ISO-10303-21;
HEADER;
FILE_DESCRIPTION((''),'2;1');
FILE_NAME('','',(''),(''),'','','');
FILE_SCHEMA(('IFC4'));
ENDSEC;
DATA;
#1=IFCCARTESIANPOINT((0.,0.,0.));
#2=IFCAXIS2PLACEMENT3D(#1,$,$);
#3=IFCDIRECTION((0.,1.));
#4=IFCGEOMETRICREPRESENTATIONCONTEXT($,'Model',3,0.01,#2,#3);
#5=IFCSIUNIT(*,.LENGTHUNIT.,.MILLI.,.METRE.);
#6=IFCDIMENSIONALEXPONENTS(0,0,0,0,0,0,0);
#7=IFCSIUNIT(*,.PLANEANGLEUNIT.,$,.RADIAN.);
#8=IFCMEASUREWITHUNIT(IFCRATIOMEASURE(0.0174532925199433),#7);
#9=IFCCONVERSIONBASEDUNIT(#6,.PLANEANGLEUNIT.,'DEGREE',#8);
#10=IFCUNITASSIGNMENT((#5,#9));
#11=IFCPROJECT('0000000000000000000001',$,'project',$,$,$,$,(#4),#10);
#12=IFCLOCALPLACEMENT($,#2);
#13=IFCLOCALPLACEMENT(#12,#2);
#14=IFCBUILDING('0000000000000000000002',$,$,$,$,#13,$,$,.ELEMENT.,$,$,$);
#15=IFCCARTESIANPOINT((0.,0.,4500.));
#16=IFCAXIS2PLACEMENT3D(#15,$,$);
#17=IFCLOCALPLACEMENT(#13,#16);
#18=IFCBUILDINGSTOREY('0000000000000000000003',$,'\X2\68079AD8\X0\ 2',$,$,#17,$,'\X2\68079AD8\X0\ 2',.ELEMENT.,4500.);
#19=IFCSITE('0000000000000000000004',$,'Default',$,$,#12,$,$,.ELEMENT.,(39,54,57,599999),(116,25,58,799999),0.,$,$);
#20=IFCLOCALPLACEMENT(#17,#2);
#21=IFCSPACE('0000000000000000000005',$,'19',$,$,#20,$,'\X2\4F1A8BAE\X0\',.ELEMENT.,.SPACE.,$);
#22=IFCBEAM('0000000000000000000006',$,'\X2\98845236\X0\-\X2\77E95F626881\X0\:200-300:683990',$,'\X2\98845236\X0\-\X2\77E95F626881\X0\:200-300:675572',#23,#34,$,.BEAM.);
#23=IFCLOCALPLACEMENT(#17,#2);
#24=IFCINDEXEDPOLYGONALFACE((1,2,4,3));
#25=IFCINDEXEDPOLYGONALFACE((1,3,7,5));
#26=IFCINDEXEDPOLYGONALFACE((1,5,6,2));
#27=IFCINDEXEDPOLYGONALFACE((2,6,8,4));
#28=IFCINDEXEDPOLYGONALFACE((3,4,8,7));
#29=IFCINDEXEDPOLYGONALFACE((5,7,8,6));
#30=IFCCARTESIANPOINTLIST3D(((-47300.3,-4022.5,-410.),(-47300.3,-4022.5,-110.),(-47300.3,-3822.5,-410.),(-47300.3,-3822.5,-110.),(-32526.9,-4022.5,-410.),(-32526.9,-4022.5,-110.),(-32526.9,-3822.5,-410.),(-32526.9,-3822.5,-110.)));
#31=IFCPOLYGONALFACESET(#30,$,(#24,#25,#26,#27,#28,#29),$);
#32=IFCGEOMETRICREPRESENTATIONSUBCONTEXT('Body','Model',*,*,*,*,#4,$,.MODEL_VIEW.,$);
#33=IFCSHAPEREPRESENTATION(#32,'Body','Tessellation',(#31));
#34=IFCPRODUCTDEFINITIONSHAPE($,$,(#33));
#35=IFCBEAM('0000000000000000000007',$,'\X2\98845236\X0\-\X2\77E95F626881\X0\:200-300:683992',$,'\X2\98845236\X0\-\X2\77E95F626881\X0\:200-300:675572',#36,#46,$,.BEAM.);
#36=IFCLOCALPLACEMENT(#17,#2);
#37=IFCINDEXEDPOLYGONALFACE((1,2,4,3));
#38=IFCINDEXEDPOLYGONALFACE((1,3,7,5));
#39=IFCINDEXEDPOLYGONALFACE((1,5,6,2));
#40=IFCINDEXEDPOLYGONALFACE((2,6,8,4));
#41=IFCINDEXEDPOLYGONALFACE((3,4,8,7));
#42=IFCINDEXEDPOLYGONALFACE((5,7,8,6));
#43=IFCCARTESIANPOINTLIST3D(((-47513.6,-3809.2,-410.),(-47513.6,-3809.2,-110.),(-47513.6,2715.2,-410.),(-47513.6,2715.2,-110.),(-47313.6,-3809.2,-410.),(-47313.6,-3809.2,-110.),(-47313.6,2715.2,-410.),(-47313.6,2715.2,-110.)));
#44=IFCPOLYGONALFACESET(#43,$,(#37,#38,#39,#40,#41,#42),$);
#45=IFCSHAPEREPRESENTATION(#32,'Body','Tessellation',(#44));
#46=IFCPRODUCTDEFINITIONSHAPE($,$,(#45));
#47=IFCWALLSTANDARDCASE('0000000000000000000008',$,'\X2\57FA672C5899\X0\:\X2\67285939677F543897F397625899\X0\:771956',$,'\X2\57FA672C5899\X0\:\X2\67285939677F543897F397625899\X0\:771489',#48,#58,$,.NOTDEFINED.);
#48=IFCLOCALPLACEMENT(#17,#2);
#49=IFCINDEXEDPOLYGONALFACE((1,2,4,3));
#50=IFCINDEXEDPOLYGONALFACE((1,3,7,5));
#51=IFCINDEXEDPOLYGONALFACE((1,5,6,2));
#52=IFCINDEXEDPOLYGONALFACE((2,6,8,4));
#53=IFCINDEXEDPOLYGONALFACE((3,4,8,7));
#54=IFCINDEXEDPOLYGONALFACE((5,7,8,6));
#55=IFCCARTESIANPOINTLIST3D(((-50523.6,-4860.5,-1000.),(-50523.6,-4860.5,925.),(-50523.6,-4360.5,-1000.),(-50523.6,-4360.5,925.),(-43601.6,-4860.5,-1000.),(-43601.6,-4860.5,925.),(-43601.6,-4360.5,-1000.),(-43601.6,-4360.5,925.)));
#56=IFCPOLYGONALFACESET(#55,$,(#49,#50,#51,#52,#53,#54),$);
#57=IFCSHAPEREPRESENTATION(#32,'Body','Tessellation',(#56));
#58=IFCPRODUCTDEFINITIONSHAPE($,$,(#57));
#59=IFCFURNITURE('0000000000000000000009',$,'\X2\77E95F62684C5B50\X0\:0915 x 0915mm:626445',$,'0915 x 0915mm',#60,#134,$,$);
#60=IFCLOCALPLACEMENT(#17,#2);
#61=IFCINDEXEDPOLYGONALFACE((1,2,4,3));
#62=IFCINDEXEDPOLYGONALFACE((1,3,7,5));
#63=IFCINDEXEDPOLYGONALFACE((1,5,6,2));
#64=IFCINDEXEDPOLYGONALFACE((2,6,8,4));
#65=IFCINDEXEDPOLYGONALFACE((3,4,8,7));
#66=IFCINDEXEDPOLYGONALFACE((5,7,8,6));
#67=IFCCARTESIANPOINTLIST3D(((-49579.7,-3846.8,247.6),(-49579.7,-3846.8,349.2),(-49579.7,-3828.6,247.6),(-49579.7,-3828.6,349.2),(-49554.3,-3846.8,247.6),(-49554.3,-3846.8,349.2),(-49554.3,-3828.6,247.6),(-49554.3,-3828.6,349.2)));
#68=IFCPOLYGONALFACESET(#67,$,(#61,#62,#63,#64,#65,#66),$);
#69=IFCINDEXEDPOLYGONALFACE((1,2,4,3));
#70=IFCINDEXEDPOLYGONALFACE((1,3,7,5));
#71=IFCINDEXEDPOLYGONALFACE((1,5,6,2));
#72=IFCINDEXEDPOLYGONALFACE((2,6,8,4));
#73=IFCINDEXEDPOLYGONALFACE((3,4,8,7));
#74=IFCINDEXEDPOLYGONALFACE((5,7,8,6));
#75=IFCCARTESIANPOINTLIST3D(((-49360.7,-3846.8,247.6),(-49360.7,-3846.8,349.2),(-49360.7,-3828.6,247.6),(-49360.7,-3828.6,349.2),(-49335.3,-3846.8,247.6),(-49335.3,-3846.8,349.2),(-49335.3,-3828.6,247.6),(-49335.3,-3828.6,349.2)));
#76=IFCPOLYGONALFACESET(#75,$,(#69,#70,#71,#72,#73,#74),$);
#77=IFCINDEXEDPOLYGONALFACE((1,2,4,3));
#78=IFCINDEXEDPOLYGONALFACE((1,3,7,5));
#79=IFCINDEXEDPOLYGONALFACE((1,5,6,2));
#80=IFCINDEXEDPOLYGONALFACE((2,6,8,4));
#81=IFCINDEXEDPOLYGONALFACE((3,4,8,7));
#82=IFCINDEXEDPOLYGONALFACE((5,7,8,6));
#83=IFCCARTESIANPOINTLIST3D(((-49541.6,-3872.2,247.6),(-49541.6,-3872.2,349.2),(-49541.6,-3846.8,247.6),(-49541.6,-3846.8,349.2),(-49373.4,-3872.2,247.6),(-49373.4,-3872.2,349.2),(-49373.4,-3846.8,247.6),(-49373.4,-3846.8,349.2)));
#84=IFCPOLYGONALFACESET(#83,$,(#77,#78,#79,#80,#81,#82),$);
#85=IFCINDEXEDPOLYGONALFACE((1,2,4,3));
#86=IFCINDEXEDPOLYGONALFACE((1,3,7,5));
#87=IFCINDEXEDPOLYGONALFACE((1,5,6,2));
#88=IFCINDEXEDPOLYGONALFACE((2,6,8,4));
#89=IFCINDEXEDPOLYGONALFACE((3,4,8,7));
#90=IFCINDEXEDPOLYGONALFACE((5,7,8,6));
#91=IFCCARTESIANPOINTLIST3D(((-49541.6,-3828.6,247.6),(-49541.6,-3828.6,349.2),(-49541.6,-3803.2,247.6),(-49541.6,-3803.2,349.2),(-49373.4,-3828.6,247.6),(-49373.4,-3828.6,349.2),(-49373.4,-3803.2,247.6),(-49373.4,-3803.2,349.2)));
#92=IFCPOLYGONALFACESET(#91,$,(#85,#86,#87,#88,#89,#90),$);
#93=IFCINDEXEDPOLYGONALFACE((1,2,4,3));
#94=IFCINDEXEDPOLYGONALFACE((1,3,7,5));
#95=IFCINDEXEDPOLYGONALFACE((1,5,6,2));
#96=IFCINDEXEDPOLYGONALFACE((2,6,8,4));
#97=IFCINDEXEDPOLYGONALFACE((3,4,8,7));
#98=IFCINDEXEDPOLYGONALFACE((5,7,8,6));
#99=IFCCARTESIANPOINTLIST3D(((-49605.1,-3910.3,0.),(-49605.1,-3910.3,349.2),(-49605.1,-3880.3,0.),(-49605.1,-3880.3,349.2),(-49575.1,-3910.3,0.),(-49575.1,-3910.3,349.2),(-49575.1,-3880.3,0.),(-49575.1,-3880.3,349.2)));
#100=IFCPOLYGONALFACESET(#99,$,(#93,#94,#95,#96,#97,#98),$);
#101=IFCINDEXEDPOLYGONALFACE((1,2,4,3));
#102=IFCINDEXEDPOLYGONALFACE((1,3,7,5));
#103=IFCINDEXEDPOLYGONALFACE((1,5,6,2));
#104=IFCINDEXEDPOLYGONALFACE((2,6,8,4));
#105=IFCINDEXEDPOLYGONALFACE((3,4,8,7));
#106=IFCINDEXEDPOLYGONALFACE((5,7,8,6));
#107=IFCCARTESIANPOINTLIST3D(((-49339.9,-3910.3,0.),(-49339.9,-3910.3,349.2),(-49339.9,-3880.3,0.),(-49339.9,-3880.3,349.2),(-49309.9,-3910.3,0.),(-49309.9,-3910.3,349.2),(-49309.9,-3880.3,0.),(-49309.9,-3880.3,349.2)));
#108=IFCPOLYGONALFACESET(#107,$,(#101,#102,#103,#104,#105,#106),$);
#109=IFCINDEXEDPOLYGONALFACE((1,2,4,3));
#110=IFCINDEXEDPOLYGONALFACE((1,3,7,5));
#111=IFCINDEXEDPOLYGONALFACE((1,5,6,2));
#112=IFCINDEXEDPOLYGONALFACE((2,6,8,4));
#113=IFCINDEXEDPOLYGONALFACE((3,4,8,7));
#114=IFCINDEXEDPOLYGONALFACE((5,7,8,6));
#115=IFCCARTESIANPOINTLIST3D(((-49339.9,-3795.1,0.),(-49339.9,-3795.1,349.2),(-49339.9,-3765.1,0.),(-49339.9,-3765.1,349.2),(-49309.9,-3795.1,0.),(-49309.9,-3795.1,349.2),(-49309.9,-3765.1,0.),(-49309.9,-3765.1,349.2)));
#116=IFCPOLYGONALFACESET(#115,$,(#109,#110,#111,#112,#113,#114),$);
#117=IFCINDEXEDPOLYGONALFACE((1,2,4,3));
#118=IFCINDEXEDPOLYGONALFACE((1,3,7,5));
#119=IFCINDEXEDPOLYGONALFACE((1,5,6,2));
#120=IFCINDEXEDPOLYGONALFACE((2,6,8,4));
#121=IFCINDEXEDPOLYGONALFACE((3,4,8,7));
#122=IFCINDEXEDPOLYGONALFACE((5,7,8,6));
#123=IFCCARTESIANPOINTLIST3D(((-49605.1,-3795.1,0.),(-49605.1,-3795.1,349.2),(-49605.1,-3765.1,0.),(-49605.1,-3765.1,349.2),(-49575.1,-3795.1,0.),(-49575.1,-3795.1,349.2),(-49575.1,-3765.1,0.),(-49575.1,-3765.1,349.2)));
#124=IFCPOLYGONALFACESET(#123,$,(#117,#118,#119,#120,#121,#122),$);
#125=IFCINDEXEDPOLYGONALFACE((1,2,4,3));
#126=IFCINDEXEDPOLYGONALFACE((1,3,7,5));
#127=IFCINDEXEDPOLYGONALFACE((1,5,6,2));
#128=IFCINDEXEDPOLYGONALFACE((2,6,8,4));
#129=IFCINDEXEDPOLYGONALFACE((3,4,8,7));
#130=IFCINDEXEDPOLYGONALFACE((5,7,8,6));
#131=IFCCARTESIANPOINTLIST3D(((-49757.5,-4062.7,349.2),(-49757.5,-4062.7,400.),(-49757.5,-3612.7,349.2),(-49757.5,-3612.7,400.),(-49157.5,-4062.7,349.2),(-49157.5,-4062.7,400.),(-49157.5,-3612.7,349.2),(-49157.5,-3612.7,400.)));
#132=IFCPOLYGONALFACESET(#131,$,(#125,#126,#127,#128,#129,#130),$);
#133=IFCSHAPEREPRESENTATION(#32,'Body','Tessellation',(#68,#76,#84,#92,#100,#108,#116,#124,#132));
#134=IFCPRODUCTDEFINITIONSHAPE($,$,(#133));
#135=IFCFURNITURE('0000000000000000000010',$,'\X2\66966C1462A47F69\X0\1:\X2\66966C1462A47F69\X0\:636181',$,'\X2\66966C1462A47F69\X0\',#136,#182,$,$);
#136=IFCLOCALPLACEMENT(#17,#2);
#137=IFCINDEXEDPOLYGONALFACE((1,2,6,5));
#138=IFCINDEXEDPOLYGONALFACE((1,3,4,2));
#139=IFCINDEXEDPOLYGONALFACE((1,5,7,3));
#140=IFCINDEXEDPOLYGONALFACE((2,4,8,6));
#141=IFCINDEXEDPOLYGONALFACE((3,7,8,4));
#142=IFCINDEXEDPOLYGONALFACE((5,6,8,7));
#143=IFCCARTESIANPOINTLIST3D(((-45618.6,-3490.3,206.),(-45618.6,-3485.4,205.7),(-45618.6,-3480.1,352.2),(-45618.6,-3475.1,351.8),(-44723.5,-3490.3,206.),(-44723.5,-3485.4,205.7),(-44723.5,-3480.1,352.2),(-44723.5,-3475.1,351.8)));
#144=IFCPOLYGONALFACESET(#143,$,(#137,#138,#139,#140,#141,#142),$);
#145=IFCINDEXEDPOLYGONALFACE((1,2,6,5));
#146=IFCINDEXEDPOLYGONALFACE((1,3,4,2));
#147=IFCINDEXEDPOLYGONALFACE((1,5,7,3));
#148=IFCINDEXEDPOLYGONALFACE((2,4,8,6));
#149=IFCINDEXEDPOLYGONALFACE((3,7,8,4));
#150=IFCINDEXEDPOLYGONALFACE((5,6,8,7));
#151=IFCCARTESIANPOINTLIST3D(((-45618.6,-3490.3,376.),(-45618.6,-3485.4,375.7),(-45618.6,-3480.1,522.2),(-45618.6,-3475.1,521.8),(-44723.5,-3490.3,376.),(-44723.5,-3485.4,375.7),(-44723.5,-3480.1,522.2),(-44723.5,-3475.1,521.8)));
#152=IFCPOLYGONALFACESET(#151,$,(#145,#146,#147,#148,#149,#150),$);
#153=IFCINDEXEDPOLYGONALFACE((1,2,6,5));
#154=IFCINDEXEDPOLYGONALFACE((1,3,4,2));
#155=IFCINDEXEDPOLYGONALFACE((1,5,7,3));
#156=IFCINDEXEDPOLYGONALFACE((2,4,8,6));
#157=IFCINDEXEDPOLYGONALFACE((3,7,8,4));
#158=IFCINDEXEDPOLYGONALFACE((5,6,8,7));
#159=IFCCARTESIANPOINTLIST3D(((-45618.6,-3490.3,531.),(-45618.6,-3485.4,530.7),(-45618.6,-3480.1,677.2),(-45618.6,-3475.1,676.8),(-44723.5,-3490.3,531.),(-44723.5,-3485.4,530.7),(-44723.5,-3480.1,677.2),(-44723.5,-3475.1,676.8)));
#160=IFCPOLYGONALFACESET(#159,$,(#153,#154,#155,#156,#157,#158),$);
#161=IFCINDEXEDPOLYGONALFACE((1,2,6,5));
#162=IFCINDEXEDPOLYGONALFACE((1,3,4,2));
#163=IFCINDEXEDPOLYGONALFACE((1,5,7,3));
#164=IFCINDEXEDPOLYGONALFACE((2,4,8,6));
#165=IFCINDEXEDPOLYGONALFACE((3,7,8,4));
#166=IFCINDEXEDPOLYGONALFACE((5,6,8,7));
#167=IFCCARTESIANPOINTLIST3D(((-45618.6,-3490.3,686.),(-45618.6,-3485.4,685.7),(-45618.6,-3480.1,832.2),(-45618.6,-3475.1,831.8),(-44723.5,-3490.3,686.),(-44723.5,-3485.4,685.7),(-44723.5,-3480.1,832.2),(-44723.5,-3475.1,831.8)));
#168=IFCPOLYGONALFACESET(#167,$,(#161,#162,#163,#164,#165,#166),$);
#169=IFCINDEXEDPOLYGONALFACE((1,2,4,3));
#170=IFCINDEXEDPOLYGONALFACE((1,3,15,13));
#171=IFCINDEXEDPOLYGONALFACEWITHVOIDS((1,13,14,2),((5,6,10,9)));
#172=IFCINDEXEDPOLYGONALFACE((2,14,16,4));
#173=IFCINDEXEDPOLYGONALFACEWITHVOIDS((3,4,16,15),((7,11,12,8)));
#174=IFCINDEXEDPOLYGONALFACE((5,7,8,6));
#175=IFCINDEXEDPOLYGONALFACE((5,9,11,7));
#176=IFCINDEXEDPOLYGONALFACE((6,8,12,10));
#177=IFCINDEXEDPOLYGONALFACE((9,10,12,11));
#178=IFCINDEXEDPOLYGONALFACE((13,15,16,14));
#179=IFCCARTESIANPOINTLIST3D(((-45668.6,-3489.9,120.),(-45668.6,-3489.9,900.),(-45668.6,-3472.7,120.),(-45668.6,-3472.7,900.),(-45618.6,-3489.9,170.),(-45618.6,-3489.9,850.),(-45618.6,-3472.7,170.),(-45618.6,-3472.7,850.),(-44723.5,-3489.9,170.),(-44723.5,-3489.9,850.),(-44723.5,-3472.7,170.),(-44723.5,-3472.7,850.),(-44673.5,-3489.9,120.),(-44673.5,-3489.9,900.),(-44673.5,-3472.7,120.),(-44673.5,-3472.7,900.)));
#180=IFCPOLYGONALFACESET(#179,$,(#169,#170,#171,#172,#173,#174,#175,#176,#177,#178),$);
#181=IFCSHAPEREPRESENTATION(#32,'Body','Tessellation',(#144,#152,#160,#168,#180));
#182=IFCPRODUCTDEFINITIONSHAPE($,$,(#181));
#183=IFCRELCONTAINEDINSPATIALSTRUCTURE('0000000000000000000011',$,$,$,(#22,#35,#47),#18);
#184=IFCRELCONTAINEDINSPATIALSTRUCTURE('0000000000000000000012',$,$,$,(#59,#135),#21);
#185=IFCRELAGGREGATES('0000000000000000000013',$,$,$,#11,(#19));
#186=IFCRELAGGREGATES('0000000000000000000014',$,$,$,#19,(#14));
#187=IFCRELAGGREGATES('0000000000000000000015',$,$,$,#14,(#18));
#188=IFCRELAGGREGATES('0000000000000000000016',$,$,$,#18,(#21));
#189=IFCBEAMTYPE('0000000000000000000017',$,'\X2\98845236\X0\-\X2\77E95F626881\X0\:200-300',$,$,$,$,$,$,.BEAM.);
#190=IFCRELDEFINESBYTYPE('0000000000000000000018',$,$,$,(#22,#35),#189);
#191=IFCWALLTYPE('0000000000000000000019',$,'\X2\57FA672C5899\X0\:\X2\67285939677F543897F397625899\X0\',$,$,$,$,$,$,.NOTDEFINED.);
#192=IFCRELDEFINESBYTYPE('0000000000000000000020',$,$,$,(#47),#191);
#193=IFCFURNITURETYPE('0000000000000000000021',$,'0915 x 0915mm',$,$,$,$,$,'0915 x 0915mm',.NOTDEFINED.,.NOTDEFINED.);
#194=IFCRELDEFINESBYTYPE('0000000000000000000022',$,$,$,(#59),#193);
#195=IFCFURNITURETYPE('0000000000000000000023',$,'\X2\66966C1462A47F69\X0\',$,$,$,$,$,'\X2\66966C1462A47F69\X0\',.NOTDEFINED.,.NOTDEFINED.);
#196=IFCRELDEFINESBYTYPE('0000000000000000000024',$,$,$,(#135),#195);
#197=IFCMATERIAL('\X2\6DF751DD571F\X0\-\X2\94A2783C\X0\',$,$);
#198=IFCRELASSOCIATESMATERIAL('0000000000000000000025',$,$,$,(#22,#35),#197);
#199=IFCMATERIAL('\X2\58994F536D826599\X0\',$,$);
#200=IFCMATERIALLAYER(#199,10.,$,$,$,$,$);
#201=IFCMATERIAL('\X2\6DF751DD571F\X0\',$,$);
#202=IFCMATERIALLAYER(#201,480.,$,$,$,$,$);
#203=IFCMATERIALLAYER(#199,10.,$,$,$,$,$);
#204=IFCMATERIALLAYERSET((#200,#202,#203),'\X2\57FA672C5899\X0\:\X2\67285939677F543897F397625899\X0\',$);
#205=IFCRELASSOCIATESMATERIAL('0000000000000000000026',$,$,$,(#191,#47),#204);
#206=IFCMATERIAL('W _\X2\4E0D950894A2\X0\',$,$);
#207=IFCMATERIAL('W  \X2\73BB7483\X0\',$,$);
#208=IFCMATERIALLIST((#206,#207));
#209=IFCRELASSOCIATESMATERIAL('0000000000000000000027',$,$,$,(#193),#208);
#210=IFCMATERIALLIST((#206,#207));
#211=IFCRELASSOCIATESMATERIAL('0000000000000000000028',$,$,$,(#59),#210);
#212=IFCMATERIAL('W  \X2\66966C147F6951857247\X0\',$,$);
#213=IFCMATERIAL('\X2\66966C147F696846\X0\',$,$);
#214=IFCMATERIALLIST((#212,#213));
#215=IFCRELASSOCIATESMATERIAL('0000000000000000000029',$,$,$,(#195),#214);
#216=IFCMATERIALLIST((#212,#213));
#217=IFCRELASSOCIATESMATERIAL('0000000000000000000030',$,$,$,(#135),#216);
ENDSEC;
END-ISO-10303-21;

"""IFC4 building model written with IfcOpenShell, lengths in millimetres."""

from ifc_helpers import new_model, entity, si_unit, converted_unit, direction, frame, frame_2d, origin, origin_2d_with_axis, place, context, subcontext, project, spatial, polyline, rectangle, outline, extrude, source, transform, mapped, material, material_list, layer, layer_set, layer_usage, type_object, type_shapes, element, save


model = new_model("IFC4")

# Units and contexts
model_context = context("Model", 3, precision=0.01, world=origin(), true_north=direction((0.0, 1.0)))
body_context = subcontext(model_context, "Body", "Model", "MODEL_VIEW")
ifc_project = project(units=[si_unit("LENGTHUNIT", "METRE", prefix="MILLI"), converted_unit("PLANEANGLEUNIT", "DEGREE", entity("IfcRatioMeasure", 0.0174532925199433), si_unit("PLANEANGLEUNIT", "RADIAN"), dimensions=[0, 0, 0, 0, 0, 0, 0])], contexts=[model_context])

# Site, building, storey
site_placement = place(None, origin())
site = spatial("IfcSite", under=ifc_project, at=site_placement, Name="Default", CompositionType="ELEMENT", RefLatitude=(39, 54, 57, 599999), RefLongitude=(116, 25, 58, 799999), RefElevation=0.0)
building_placement = place(site_placement, origin())
building = spatial("IfcBuilding", under=site, at=building_placement, CompositionType="ELEMENT")
storey_placement = place(building_placement, frame((0.0, 0.0, 4500.0)))
storey = spatial("IfcBuildingStorey", under=building, at=storey_placement, Name="标高 2", LongName="标高 2", CompositionType="ELEMENT", Elevation=4500.0)

# Beams
ifc_material_1 = material(Name="混凝土-钢砼")
beam_type = type_object("IfcBeamType", Name="预制-矩形梁:200-300", PredefinedType="BEAM")
beam_1_placement = place(storey_placement, frame((-47413.6, -3922.5, -110.0)))
element("IfcBeam", 1, at=beam_1_placement, inside=storey, type_object=beam_type, material=ifc_material_1, Name="预制-矩形梁:200-300:683990", ObjectType="预制-矩形梁:200-300:675572", PredefinedType="BEAM", context=body_context, shape_type="SweptSolid", body=[
    extrude(rectangle(XDim=300.0, YDim=200.0, at=frame_2d((0.0, 0.0), x_axis=(1.0, 0.0))), frame((113.3, 0.0, -150.0), z_axis=(1.0, 0.0, 0.0), x_axis=(0.0, 0.0, -1.0)), (0.0, 0.0, 1.0), 14773.4),
])
beam_2_placement = place(storey_placement, frame((-47413.6, -3922.5, -110.0), z_axis=(0.0, 0.0, 1.0), x_axis=(0.0, 1.0, 0.0)))
element("IfcBeam", 2, at=beam_2_placement, inside=storey, type_object=beam_type, material=ifc_material_1, Name="预制-矩形梁:200-300:683992", ObjectType="预制-矩形梁:200-300:675572", PredefinedType="BEAM", context=body_context, shape_type="SweptSolid", body=[
    extrude(rectangle(XDim=300.0, YDim=200.0, at=origin_2d_with_axis()), frame((113.3, 0.0, -150.0), z_axis=(1.0, 0.0, 0.0), x_axis=(0.0, 0.0, -1.0)), (0.0, 0.0, 1.0), 6524.4),
])

# Wall
ifc_material_2 = material(Name="墙体涂料")
ifc_layer_1 = layer(ifc_material_2, 10.0)
ifc_material_3 = material(Name="混凝土")
ifc_layer_2 = layer(ifc_material_3, 480.0)
ifc_layer_3 = layer(ifc_material_2, 10.0)
ifc_layer_set = layer_set([ifc_layer_1, ifc_layer_2, ifc_layer_3], Name="基本墙:木夹板吸音面墙")
ifc_layer_usage = layer_usage(ifc_layer_set, "AXIS2", "NEGATIVE", 250.0)
wall_type = type_object("IfcWallType", Name="基本墙:木夹板吸音面墙", PredefinedType="NOTDEFINED", material=ifc_layer_set)
wall_placement = place(storey_placement, frame((-43601.6, -4610.5, -1000.0), z_axis=(0.0, 0.0, 1.0), x_axis=(-1.0, 0.0, 0.0)))
element("IfcWallStandardCase", 3, at=wall_placement, inside=storey, type_object=wall_type, material=ifc_layer_usage, Name="基本墙:木夹板吸音面墙:771956", ObjectType="基本墙:木夹板吸音面墙:771489", PredefinedType="NOTDEFINED", context=body_context, shape_type="SweptSolid", body=[
    extrude(rectangle(XDim=6922.0, YDim=500.0, at=frame_2d((3461.0, 0.0), x_axis=(-1.0, 0.0))), origin(), (0.0, 0.0, 1.0), 1925.0),
])

# Shared definitions
space_placement = place(storey_placement, origin())
space = spatial("IfcSpace", under=storey, at=space_placement, Name="19", LongName="会议", CompositionType="ELEMENT", PredefinedType="SPACE")

# Furniture
ifc_material_4 = material(Name="W _不锈钢")
ifc_material_5 = material(Name="W  玻璃")
ifc_material_list_1 = material_list([ifc_material_4, ifc_material_5])
ifc_material_list_2 = material_list([ifc_material_4, ifc_material_5])
furniture_type_1 = type_object("IfcFurnitureType", Name="0915 x 0915mm", ElementType="0915 x 0915mm", AssemblyPlace="NOTDEFINED", PredefinedType="NOTDEFINED", material=ifc_material_list_2)
shared_shape_1 = source(origin(), body_context, "Body", "SweptSolid", [
    extrude(rectangle(XDim=25.4, YDim=18.2, at=origin_2d_with_axis()), frame((109.5, 0.0, 247.6)), (0.0, 0.0, 1.0), 101.6),
    extrude(rectangle(XDim=18.2, YDim=25.4, at=origin_2d_with_axis()), frame((-109.5, 0.0, 247.6), z_axis=(0.0, 0.0, 1.0), x_axis=(0.0, 1.0, 0.0)), (0.0, 0.0, 1.0), 101.6),
    extrude(rectangle(XDim=168.2, YDim=25.4, at=frame_2d((0.0, 0.0), x_axis=(1.0, 0.0))), frame((0.0, 21.8, 247.6), z_axis=(0.0, 0.0, 1.0), x_axis=(-1.0, 0.0, 0.0)), (0.0, 0.0, 1.0), 101.6),
    extrude(rectangle(XDim=25.4, YDim=168.2, at=origin_2d_with_axis()), frame((0.0, -21.8, 247.6), z_axis=(0.0, 0.0, 1.0), x_axis=(0.0, 1.0, 0.0)), (0.0, 0.0, 1.0), 101.6),
    extrude(rectangle(XDim=30.0, YDim=30.0, at=origin_2d_with_axis()), frame((132.6, 57.6, 0.0), z_axis=(0.0, 0.0, 1.0), x_axis=(0.0, -1.0, 0.0)), (0.0, 0.0, 1.0), 349.2),
    extrude(rectangle(XDim=30.0, YDim=30.0, at=frame_2d((0.0, 0.0), x_axis=(1.0, 0.0))), frame((-132.6, 57.6, 0.0), z_axis=(0.0, 0.0, 1.0), x_axis=(-1.0, 0.0, 0.0)), (0.0, 0.0, 1.0), 349.2),
    extrude(rectangle(XDim=30.0, YDim=30.0, at=frame_2d((0.0, 0.0), x_axis=(1.0, 0.0))), frame((-132.6, -57.6, 0.0), z_axis=(0.0, 0.0, 1.0), x_axis=(0.0, 1.0, 0.0)), (0.0, 0.0, 1.0), 349.2),
    extrude(rectangle(XDim=30.0, YDim=30.0, at=frame_2d((0.0, 0.0), x_axis=(1.0, 0.0))), frame((132.6, -57.6, 0.0)), (0.0, 0.0, 1.0), 349.2),
    extrude(rectangle(XDim=600.0, YDim=450.0, at=origin_2d_with_axis()), frame((0.0, 0.0, 349.2), z_axis=(0.0, 0.0, 1.0), x_axis=(-1.0, 0.0, 0.0)), (0.0, 0.0, 1.0), 50.8),
])
type_shapes(furniture_type_1, [shared_shape_1])
furniture_1_placement = place(space_placement, frame((-49457.5, -3837.7, 0.0), z_axis=(0.0, 0.0, 1.0), x_axis=(-1.0, 0.0, 0.0)))
element("IfcFurniture", 4, at=furniture_1_placement, inside=space, type_object=furniture_type_1, material=ifc_material_list_1, Name="矩形桌子:0915 x 0915mm:626445", ObjectType="0915 x 0915mm", context=body_context, shape_type="MappedRepresentation", body=[
    mapped(shared_shape_1, transform((0.0, 0.0, 0.0), scale=1.0)),
])
ifc_material_6 = material(Name="W  暖气罩内片")
ifc_material_7 = material(Name="暖气罩框")
ifc_material_list_3 = material_list([ifc_material_6, ifc_material_7])
ifc_material_list_4 = material_list([ifc_material_6, ifc_material_7])
furniture_type_2 = type_object("IfcFurnitureType", Name="暖气护罩", ElementType="暖气护罩", AssemblyPlace="NOTDEFINED", PredefinedType="NOTDEFINED", material=ifc_material_list_4)
shared_shape_2 = source(origin(), body_context, "Body", "SweptSolid", [
    extrude(rectangle(XDim=146.5, YDim=5.0, at=frame_2d((0.0, 0.0), x_axis=(0.0, 1.0))), frame((50.0, 7.6, 158.9), z_axis=(1.0, 0.0, 0.0), x_axis=(0.0, -0.997564, 0.069756)), (0.0, 0.0, 1.0), 895.1),
    extrude(rectangle(XDim=146.5, YDim=5.0, at=frame_2d((0.0, 0.0), x_axis=(0.0, 1.0))), frame((50.0, 7.6, 328.9), z_axis=(1.0, 0.0, 0.0), x_axis=(0.0, -0.997564, 0.069756)), (0.0, 0.0, 1.0), 895.1),
    extrude(rectangle(XDim=146.5, YDim=5.0, at=frame_2d((0.0, 0.0), x_axis=(0.0, 1.0))), frame((50.0, 7.6, 483.9), z_axis=(1.0, 0.0, 0.0), x_axis=(0.0, -0.997564, 0.069756)), (0.0, 0.0, 1.0), 895.1),
    extrude(rectangle(XDim=146.5, YDim=5.0, at=frame_2d((0.0, 0.0), x_axis=(0.0, 1.0))), frame((50.0, 7.6, 638.9), z_axis=(1.0, 0.0, 0.0), x_axis=(0.0, -0.997564, 0.069756)), (0.0, 0.0, 1.0), 895.1),
    extrude(outline(polyline([(-497.5, -390.0), (497.5, -390.0), (497.5, 390.0), (-497.5, 390.0), (-497.5, -390.0)]), holes=[polyline([(-447.5, -340.0), (-447.5, 340.0), (447.5, 340.0), (447.5, -340.0), (-447.5, -340.0)])]), frame((497.5, 0.5, 390.0), z_axis=(0.0, 1.0, 0.0), x_axis=(1.0, 0.0, 0.0)), (0.0, 0.0, 1.0), 17.2),
])
type_shapes(furniture_type_2, [shared_shape_2])
furniture_2_placement = place(space_placement, frame((-45668.6, -3490.3, 120.0)))
element("IfcFurniture", 5, at=furniture_2_placement, inside=space, type_object=furniture_type_2, material=ifc_material_list_3, Name="暖气护罩1:暖气护罩:636181", ObjectType="暖气护罩", context=body_context, shape_type="MappedRepresentation", body=[
    mapped(shared_shape_2, transform((0.0, 0.0, 0.0), scale=1.0)),
])

save(model, "model.ifc")
